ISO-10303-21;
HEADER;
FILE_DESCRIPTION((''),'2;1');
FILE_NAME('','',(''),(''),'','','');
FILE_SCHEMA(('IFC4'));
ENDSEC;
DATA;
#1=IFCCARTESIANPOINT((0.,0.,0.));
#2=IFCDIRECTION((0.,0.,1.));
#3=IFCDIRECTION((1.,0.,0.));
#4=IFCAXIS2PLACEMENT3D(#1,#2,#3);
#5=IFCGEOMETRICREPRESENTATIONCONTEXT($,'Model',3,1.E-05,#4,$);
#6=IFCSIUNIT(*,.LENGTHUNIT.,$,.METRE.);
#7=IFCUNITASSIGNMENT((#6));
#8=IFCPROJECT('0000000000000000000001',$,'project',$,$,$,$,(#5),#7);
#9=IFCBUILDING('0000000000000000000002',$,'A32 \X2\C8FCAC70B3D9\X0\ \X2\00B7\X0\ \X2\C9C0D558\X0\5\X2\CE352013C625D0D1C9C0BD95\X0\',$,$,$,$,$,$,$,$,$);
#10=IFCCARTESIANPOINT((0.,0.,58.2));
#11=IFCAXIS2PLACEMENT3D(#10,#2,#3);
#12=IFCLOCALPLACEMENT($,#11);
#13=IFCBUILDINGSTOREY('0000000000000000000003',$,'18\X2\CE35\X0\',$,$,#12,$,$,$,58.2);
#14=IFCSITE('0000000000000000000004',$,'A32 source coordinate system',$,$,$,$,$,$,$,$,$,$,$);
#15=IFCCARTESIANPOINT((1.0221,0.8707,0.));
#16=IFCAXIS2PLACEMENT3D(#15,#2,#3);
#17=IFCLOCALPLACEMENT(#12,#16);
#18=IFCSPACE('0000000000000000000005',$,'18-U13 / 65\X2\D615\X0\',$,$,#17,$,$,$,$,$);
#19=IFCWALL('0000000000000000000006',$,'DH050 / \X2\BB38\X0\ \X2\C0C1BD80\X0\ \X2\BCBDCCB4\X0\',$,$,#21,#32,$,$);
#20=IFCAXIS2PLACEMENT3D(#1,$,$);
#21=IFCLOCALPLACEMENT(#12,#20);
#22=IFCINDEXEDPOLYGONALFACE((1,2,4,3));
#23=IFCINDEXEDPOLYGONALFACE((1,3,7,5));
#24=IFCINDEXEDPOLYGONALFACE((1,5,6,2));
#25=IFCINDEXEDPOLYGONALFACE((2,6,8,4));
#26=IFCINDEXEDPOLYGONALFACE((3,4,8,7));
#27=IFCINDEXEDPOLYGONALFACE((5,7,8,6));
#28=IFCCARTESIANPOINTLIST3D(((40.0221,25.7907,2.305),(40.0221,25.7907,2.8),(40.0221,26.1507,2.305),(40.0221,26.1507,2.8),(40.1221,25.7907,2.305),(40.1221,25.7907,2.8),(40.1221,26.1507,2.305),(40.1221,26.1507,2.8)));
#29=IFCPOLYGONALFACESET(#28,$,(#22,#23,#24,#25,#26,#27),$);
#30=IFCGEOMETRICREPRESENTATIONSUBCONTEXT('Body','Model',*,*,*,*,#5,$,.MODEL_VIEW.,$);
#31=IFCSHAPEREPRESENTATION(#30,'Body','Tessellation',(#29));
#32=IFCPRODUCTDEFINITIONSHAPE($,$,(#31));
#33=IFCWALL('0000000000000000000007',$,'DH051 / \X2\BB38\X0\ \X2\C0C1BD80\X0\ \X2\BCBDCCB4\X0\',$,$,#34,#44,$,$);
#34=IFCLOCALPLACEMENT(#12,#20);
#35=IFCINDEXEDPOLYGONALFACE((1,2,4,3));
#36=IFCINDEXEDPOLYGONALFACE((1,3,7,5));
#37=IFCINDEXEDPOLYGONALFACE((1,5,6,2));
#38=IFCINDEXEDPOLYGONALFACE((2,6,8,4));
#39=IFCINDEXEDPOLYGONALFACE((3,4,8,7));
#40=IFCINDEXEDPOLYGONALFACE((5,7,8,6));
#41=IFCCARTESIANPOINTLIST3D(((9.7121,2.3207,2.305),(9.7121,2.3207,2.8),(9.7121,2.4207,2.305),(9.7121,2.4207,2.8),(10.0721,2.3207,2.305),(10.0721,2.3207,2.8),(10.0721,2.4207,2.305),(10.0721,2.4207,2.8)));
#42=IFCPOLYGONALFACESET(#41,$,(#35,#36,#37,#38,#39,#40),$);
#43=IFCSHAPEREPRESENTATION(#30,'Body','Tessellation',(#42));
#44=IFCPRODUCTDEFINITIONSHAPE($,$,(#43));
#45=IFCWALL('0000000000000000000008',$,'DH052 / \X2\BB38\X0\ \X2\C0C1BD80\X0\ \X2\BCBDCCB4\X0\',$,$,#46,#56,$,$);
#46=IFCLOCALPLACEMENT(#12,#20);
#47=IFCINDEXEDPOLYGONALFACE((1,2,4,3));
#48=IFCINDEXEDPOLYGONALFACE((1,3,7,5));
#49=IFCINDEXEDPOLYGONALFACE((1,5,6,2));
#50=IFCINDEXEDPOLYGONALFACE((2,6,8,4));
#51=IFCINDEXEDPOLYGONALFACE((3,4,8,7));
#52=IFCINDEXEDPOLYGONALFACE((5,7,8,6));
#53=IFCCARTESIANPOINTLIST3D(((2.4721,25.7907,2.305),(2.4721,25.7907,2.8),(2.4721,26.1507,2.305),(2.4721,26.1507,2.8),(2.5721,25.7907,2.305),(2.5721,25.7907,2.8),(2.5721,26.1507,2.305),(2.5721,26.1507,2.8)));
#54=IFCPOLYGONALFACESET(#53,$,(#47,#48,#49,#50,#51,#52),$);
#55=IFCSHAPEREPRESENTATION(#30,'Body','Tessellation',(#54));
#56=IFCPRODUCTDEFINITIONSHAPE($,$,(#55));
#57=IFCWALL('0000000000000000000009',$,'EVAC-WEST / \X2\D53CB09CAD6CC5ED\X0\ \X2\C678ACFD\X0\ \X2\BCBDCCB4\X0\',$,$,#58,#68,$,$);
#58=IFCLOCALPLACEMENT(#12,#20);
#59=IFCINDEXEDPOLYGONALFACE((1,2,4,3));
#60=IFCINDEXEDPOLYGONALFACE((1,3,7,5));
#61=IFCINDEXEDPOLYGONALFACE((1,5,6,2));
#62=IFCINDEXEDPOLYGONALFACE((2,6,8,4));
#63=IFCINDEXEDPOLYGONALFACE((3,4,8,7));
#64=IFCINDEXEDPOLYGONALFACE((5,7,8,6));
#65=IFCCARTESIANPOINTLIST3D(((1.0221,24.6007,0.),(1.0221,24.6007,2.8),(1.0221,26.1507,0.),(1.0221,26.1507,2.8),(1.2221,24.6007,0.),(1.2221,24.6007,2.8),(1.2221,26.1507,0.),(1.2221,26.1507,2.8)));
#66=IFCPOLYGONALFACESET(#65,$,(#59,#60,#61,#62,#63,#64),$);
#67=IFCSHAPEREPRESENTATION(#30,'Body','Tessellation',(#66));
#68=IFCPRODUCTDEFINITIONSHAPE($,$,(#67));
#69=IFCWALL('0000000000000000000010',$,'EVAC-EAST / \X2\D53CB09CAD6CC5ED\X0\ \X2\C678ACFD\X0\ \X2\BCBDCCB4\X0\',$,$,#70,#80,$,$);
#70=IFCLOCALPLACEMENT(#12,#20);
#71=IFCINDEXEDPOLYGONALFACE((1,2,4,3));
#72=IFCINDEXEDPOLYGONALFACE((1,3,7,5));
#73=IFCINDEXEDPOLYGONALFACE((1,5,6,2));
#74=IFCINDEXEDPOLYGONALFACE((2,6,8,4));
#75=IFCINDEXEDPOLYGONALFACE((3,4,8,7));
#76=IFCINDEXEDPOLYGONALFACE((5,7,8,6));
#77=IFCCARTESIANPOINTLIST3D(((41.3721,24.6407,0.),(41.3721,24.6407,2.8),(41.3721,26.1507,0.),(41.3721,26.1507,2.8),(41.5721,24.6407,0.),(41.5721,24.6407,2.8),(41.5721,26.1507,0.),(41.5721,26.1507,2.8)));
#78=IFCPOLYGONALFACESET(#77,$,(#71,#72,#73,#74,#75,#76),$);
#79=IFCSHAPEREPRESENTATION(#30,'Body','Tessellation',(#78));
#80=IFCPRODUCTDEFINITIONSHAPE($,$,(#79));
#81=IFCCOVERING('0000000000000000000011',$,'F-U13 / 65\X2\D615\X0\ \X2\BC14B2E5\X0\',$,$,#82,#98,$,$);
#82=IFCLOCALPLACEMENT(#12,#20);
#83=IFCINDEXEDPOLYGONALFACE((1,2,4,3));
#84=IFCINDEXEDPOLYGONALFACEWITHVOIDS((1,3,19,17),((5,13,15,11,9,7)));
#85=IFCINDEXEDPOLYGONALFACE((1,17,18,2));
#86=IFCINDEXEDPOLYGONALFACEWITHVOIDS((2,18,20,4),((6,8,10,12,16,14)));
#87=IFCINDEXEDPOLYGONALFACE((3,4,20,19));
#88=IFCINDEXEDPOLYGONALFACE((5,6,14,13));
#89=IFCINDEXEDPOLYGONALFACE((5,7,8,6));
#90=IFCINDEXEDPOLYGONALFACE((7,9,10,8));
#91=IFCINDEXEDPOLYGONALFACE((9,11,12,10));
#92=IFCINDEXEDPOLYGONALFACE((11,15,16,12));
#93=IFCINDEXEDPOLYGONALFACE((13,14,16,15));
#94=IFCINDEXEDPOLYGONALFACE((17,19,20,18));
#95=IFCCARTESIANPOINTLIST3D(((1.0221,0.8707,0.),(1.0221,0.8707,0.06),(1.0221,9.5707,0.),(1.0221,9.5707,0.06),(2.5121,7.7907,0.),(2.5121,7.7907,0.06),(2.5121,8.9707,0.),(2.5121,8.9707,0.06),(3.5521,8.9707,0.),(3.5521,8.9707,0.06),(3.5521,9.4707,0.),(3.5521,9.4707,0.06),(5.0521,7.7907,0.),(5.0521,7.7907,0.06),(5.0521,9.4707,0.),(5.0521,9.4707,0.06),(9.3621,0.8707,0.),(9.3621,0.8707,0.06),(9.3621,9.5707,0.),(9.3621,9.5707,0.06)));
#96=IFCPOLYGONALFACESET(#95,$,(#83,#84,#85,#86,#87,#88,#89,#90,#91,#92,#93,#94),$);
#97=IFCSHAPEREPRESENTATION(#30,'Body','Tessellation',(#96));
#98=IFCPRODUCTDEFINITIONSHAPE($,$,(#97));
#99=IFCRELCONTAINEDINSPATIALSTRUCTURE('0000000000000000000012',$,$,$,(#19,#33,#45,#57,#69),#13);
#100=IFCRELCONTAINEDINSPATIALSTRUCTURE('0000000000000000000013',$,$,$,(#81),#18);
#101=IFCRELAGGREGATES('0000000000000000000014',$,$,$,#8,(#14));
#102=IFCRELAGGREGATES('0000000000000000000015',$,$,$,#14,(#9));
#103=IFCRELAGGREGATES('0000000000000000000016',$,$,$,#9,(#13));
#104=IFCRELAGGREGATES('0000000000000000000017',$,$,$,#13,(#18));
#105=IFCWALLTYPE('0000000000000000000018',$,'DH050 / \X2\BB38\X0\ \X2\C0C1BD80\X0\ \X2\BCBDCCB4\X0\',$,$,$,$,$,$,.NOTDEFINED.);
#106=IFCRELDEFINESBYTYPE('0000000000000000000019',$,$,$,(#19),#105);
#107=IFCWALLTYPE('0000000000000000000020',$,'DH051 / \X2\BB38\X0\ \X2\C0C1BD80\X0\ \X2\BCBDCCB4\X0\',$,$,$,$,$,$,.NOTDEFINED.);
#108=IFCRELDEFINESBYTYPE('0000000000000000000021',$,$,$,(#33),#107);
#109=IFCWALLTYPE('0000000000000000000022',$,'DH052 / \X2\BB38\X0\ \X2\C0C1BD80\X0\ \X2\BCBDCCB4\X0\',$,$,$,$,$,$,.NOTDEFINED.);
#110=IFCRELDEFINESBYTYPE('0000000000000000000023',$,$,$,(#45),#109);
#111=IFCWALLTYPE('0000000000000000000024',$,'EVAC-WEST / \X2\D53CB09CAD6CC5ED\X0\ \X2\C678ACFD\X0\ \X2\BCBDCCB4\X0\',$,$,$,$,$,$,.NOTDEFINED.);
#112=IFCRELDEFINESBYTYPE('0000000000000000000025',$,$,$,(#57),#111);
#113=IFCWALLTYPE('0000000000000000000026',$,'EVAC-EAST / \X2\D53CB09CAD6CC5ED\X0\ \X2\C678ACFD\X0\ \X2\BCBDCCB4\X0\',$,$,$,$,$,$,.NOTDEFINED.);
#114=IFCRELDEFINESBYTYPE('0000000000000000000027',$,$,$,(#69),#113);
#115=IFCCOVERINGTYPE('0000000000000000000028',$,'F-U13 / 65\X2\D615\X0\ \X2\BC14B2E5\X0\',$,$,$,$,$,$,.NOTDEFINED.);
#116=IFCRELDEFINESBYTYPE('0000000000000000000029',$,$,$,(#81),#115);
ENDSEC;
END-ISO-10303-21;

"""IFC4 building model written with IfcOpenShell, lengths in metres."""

from ifc_helpers import new_model, si_unit, frame, origin, origin_with_axes, place, context, subcontext, project, spatial, polyline, outline, extrude, source, transform, mapped, type_object, type_shapes, element, save


model = new_model("IFC4")

# Units and contexts
model_context = context("Model", 3, precision=1e-05, world=origin_with_axes())
body_context = subcontext(model_context, "Body", "Model", "MODEL_VIEW")
ifc_project = project(units=[si_unit("LENGTHUNIT", "METRE")], contexts=[model_context])

# Site, building, storey
site = spatial("IfcSite", under=ifc_project, Name="A32 source coordinate system")
building = spatial("IfcBuilding", under=site, Name="A32 주거동 · 지하5층–옥탑지붕")
storey_placement = place(None, frame((0.0, 0.0, 58.2), z_axis=(0.0, 0.0, 1.0), x_axis=(1.0, 0.0, 0.0)))
storey = spatial("IfcBuildingStorey", under=building, at=storey_placement, Name="18층", Elevation=58.2)

# Walls
wall_type_1 = type_object("IfcWallType", Name="DH050 / 문 상부 벽체", PredefinedType="NOTDEFINED")
shared_shape_1 = source(origin(), body_context, "Body", "SweptSolid", [
    extrude(outline(polyline([(40.0221, 25.7907), (40.0221, 26.1507), (40.1221, 26.1507), (40.1221, 25.7907), (40.0221, 25.7907)])), frame((0.0, 0.0, 2.305)), (0.0, 0.0, 1.0), 0.495),
])
type_shapes(wall_type_1, [shared_shape_1])
wall_1_placement = place(storey_placement, origin_with_axes())
element("IfcWall", 1, at=wall_1_placement, inside=storey, type_object=wall_type_1, Name="DH050 / 문 상부 벽체", context=body_context, shape_type="MappedRepresentation", body=[
    mapped(shared_shape_1, transform((0.0, 0.0, 0.0), scale=1.0)),
])
wall_type_2 = type_object("IfcWallType", Name="DH051 / 문 상부 벽체", PredefinedType="NOTDEFINED")
shared_shape_2 = source(origin(), body_context, "Body", "SweptSolid", [
    extrude(outline(polyline([(10.0721, 2.3207), (9.7121, 2.3207), (9.7121, 2.4207), (10.0721, 2.4207), (10.0721, 2.3207)])), frame((0.0, 0.0, 2.305)), (0.0, 0.0, 1.0), 0.495),
])
type_shapes(wall_type_2, [shared_shape_2])
wall_2_placement = place(storey_placement, origin_with_axes())
element("IfcWall", 2, at=wall_2_placement, inside=storey, type_object=wall_type_2, Name="DH051 / 문 상부 벽체", context=body_context, shape_type="MappedRepresentation", body=[
    mapped(shared_shape_2, transform((0.0, 0.0, 0.0), scale=1.0)),
])
wall_type_3 = type_object("IfcWallType", Name="DH052 / 문 상부 벽체", PredefinedType="NOTDEFINED")
shared_shape_3 = source(origin(), body_context, "Body", "SweptSolid", [
    extrude(outline(polyline([(2.5721, 25.7907), (2.4721, 25.7907), (2.4721, 26.1507), (2.5721, 26.1507), (2.5721, 25.7907)])), frame((0.0, 0.0, 2.305)), (0.0, 0.0, 1.0), 0.495),
])
type_shapes(wall_type_3, [shared_shape_3])
wall_3_placement = place(storey_placement, origin_with_axes())
element("IfcWall", 3, at=wall_3_placement, inside=storey, type_object=wall_type_3, Name="DH052 / 문 상부 벽체", context=body_context, shape_type="MappedRepresentation", body=[
    mapped(shared_shape_3, transform((0.0, 0.0, 0.0), scale=1.0)),
])
wall_type_4 = type_object("IfcWallType", Name="EVAC-WEST / 피난구역 외곽 벽체", PredefinedType="NOTDEFINED")
shared_shape_4 = source(origin(), body_context, "Body", "SweptSolid", [
    extrude(outline(polyline([(1.2221, 24.6007), (1.0221, 24.6007), (1.0221, 26.1507), (1.2221, 26.1507), (1.2221, 24.6007)])), origin(), (0.0, 0.0, 1.0), 2.8),
])
type_shapes(wall_type_4, [shared_shape_4])
wall_4_placement = place(storey_placement, origin_with_axes())
element("IfcWall", 4, at=wall_4_placement, inside=storey, type_object=wall_type_4, Name="EVAC-WEST / 피난구역 외곽 벽체", context=body_context, shape_type="MappedRepresentation", body=[
    mapped(shared_shape_4, transform((0.0, 0.0, 0.0), scale=1.0)),
])
wall_type_5 = type_object("IfcWallType", Name="EVAC-EAST / 피난구역 외곽 벽체", PredefinedType="NOTDEFINED")
shared_shape_5 = source(origin(), body_context, "Body", "SweptSolid", [
    extrude(outline(polyline([(41.5721, 26.1507), (41.5721, 24.6407), (41.3721, 24.6407), (41.3721, 26.1507), (41.5721, 26.1507)])), origin(), (0.0, 0.0, 1.0), 2.8),
])
type_shapes(wall_type_5, [shared_shape_5])
wall_5_placement = place(storey_placement, origin_with_axes())
element("IfcWall", 5, at=wall_5_placement, inside=storey, type_object=wall_type_5, Name="EVAC-EAST / 피난구역 외곽 벽체", context=body_context, shape_type="MappedRepresentation", body=[
    mapped(shared_shape_5, transform((0.0, 0.0, 0.0), scale=1.0)),
])

# Shared definitions
space_placement = place(storey_placement, frame((1.0221, 0.8707, 0.0), z_axis=(0.0, 0.0, 1.0), x_axis=(1.0, 0.0, 0.0)))
space = spatial("IfcSpace", under=storey, at=space_placement, Name="18-U13 / 65형")

# Covering
covering_type_1 = type_object("IfcCoveringType", Name="F-U13 / 65형 바닥", PredefinedType="NOTDEFINED")
shared_shape_6 = source(origin(), body_context, "Body", "SweptSolid", [
    extrude(outline(polyline([(0.0, 0.0), (0.0, 8.7), (8.34, 8.7), (8.34, 0.0), (0.0, 0.0)]), holes=[polyline([(2.53, 8.1), (1.49, 8.1), (1.49, 6.92), (4.03, 6.92), (4.03, 8.6), (2.53, 8.6), (2.53, 8.1)])]), origin(), (0.0, 0.0, 1.0), 0.06),
])
type_shapes(covering_type_1, [shared_shape_6])
covering_1_placement = place(space_placement, origin_with_axes())
element("IfcCovering", 6, at=covering_1_placement, inside=space, type_object=covering_type_1, Name="F-U13 / 65형 바닥", context=body_context, shape_type="MappedRepresentation", body=[
    mapped(shared_shape_6, transform((0.0, 0.0, 0.0), scale=1.0)),
])

save(model, "model.ifc")
